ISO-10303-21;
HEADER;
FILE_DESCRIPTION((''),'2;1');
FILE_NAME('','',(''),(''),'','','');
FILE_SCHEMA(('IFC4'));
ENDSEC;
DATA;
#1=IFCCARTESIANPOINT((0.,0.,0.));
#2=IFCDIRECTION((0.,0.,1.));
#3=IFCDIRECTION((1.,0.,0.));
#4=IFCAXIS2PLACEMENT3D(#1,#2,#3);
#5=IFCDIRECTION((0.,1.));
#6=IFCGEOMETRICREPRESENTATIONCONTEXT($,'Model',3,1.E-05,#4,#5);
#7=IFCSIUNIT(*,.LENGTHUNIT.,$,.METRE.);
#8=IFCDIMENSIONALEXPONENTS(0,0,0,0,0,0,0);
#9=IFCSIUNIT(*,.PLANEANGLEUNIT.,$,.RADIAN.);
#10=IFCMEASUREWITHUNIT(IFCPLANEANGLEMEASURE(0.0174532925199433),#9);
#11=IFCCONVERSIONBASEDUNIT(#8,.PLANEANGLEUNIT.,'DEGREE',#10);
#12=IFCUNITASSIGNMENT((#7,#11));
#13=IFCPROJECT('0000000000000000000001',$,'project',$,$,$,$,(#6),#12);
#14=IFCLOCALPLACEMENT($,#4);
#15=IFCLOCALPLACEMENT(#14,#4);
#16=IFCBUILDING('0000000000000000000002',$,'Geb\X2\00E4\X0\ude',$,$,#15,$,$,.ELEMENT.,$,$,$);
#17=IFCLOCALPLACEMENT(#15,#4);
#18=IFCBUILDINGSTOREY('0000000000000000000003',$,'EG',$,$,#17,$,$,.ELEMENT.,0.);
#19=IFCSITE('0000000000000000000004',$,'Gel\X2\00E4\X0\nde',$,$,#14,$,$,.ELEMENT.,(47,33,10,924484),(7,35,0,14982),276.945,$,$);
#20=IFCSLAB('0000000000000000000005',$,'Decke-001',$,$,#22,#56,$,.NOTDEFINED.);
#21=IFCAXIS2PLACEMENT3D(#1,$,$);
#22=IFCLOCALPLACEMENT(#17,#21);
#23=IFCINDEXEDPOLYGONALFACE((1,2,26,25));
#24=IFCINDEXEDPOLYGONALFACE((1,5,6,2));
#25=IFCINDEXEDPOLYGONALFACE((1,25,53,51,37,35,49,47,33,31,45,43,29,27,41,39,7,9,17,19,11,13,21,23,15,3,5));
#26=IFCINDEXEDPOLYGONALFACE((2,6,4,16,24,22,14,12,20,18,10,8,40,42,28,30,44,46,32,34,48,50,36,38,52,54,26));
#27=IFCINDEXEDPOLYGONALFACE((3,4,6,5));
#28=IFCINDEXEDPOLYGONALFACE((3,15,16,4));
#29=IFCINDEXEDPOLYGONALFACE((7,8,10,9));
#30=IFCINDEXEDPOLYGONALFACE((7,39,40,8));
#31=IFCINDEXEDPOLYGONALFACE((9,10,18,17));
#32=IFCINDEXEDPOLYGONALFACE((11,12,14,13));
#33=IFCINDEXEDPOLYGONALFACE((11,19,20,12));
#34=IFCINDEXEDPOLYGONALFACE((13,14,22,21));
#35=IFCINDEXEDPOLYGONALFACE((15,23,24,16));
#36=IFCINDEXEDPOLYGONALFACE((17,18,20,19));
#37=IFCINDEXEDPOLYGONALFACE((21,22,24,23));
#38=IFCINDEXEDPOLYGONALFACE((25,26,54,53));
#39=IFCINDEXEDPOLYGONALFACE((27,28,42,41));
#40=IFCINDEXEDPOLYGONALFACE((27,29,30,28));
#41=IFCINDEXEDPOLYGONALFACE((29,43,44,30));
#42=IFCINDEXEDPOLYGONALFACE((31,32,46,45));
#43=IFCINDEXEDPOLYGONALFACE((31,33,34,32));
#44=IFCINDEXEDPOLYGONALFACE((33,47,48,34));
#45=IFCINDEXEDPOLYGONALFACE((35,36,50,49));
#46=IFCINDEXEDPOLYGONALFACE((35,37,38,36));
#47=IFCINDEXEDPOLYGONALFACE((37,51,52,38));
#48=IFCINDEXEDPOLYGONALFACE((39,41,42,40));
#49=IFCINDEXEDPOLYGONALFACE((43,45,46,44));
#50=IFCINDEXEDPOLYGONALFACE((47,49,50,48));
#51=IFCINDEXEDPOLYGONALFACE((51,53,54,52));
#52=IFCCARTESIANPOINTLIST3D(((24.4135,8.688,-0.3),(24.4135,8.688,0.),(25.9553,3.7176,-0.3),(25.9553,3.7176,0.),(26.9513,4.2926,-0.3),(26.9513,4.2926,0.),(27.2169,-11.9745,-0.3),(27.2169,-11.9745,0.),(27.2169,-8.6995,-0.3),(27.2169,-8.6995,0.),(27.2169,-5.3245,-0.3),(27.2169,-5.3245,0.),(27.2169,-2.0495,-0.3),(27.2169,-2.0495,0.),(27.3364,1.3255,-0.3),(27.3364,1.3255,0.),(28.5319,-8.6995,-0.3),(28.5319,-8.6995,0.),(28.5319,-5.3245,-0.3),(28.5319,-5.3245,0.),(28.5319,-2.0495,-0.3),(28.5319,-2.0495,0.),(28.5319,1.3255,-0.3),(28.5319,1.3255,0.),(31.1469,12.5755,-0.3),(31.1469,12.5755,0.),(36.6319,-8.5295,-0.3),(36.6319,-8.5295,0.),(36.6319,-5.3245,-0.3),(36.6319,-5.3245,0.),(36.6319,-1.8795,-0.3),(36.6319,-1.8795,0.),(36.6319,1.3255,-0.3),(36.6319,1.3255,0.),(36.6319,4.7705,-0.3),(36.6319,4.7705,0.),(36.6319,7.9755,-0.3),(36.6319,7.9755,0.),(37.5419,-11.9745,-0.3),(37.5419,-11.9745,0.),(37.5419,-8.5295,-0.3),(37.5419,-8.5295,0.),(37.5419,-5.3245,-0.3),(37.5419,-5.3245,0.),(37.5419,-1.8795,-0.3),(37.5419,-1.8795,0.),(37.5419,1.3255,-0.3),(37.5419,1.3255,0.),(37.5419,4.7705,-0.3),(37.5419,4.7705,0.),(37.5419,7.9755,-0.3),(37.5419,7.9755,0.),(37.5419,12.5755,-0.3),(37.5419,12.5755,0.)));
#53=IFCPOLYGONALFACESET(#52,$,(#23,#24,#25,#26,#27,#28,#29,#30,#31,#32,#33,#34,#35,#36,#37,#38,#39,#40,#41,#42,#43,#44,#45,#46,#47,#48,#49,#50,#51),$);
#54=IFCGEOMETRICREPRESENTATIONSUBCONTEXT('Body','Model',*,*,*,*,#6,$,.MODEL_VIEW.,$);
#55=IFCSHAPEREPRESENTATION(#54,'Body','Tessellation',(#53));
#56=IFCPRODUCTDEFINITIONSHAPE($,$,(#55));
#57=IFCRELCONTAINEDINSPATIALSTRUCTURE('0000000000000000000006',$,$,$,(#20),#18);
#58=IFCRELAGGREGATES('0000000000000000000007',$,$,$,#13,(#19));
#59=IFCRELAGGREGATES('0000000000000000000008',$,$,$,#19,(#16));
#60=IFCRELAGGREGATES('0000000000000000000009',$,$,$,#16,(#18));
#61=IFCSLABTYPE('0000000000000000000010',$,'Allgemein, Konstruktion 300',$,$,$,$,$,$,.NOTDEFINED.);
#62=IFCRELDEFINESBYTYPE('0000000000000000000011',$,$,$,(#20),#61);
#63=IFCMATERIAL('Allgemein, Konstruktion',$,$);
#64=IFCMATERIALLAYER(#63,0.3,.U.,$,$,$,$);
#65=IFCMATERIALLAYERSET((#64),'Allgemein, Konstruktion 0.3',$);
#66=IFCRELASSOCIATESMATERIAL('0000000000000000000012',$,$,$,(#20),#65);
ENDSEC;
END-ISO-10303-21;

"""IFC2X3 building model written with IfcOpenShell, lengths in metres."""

from ifc_helpers import new_model, entity, si_unit, converted_unit, direction, frame, origin_with_axes, place, context, subcontext, project, spatial, polyline, outline, extrude, material, layer, layer_set, layer_usage, type_object, element, save


model = new_model("IFC2X3")

# Units and contexts
model_context = context("Model", 3, precision=1e-05, world=origin_with_axes(), true_north=direction((0.0, 1.0)))
body_context = subcontext(model_context, "Body", "Model", "MODEL_VIEW")
ifc_project = project(units=[si_unit("LENGTHUNIT", "METRE"), converted_unit("PLANEANGLEUNIT", "DEGREE", entity("IfcPlaneAngleMeasure", 0.0174532925199433), si_unit("PLANEANGLEUNIT", "RADIAN"), dimensions=[0, 0, 0, 0, 0, 0, 0])], contexts=[model_context])

# Site, building, storey
site_placement = place(None, origin_with_axes())
site = spatial("IfcSite", under=ifc_project, at=site_placement, Name="Gelände", CompositionType="ELEMENT", RefLatitude=(47, 33, 10, 924484), RefLongitude=(7, 35, 0, 14982), RefElevation=276.945)
building_placement = place(site_placement, origin_with_axes())
building = spatial("IfcBuilding", under=site, at=building_placement, Name="Gebäude", CompositionType="ELEMENT")
storey_placement = place(building_placement, origin_with_axes())
storey = spatial("IfcBuildingStorey", under=building, at=storey_placement, Name="EG", CompositionType="ELEMENT", Elevation=0.0)

# Slab
ifc_material = material(Name="Allgemein, Konstruktion")
ifc_layer = layer(ifc_material, 0.3, ventilated="UNKNOWN")
ifc_layer_set = layer_set([ifc_layer], Name="Allgemein, Konstruktion 0.3")
ifc_layer_usage = layer_usage(ifc_layer_set, "AXIS3", "NEGATIVE", 0.3)
slab_type = type_object("IfcSlabType", Name="Allgemein, Konstruktion 300", PredefinedType="NOTDEFINED")
slab_placement = place(storey_placement, frame((31.1469, 12.5755, 0.0), z_axis=(0.0, 0.0, 1.0), x_axis=(1.0, 0.0, 0.0)))
element("IfcSlab", 1, at=slab_placement, inside=storey, type_object=slab_type, material=ifc_layer_usage, Name="Decke-001", PredefinedType="NOTDEFINED", context=body_context, shape_type="SweptSolid", body=[
    extrude(outline(polyline([(0.0, 0.0), (-6.7333, -3.8875), (-4.1956, -8.283), (-5.1916, -8.858), (-3.8105, -11.25), (-2.615, -11.25), (-2.615, -14.625), (-3.93, -14.625), (-3.93, -17.9), (-2.615, -17.9), (-2.615, -21.275), (-3.93, -21.275), (-3.93, -24.55), (6.395, -24.55), (6.395, -21.105), (5.485, -21.105), (5.485, -17.9), (6.395, -17.9), (6.395, -14.455), (5.485, -14.455), (5.485, -11.25), (6.395, -11.25), (6.395, -7.805), (5.485, -7.805), (5.485, -4.6), (6.395, -4.6), (6.395, 0.0), (0.0, 0.0)])), frame((0.0, 0.0, -0.3), z_axis=(0.0, 0.0, 1.0), x_axis=(1.0, 0.0, 0.0)), (0.0, 0.0, 1.0), 0.3),
])

save(model, "model.ifc")
